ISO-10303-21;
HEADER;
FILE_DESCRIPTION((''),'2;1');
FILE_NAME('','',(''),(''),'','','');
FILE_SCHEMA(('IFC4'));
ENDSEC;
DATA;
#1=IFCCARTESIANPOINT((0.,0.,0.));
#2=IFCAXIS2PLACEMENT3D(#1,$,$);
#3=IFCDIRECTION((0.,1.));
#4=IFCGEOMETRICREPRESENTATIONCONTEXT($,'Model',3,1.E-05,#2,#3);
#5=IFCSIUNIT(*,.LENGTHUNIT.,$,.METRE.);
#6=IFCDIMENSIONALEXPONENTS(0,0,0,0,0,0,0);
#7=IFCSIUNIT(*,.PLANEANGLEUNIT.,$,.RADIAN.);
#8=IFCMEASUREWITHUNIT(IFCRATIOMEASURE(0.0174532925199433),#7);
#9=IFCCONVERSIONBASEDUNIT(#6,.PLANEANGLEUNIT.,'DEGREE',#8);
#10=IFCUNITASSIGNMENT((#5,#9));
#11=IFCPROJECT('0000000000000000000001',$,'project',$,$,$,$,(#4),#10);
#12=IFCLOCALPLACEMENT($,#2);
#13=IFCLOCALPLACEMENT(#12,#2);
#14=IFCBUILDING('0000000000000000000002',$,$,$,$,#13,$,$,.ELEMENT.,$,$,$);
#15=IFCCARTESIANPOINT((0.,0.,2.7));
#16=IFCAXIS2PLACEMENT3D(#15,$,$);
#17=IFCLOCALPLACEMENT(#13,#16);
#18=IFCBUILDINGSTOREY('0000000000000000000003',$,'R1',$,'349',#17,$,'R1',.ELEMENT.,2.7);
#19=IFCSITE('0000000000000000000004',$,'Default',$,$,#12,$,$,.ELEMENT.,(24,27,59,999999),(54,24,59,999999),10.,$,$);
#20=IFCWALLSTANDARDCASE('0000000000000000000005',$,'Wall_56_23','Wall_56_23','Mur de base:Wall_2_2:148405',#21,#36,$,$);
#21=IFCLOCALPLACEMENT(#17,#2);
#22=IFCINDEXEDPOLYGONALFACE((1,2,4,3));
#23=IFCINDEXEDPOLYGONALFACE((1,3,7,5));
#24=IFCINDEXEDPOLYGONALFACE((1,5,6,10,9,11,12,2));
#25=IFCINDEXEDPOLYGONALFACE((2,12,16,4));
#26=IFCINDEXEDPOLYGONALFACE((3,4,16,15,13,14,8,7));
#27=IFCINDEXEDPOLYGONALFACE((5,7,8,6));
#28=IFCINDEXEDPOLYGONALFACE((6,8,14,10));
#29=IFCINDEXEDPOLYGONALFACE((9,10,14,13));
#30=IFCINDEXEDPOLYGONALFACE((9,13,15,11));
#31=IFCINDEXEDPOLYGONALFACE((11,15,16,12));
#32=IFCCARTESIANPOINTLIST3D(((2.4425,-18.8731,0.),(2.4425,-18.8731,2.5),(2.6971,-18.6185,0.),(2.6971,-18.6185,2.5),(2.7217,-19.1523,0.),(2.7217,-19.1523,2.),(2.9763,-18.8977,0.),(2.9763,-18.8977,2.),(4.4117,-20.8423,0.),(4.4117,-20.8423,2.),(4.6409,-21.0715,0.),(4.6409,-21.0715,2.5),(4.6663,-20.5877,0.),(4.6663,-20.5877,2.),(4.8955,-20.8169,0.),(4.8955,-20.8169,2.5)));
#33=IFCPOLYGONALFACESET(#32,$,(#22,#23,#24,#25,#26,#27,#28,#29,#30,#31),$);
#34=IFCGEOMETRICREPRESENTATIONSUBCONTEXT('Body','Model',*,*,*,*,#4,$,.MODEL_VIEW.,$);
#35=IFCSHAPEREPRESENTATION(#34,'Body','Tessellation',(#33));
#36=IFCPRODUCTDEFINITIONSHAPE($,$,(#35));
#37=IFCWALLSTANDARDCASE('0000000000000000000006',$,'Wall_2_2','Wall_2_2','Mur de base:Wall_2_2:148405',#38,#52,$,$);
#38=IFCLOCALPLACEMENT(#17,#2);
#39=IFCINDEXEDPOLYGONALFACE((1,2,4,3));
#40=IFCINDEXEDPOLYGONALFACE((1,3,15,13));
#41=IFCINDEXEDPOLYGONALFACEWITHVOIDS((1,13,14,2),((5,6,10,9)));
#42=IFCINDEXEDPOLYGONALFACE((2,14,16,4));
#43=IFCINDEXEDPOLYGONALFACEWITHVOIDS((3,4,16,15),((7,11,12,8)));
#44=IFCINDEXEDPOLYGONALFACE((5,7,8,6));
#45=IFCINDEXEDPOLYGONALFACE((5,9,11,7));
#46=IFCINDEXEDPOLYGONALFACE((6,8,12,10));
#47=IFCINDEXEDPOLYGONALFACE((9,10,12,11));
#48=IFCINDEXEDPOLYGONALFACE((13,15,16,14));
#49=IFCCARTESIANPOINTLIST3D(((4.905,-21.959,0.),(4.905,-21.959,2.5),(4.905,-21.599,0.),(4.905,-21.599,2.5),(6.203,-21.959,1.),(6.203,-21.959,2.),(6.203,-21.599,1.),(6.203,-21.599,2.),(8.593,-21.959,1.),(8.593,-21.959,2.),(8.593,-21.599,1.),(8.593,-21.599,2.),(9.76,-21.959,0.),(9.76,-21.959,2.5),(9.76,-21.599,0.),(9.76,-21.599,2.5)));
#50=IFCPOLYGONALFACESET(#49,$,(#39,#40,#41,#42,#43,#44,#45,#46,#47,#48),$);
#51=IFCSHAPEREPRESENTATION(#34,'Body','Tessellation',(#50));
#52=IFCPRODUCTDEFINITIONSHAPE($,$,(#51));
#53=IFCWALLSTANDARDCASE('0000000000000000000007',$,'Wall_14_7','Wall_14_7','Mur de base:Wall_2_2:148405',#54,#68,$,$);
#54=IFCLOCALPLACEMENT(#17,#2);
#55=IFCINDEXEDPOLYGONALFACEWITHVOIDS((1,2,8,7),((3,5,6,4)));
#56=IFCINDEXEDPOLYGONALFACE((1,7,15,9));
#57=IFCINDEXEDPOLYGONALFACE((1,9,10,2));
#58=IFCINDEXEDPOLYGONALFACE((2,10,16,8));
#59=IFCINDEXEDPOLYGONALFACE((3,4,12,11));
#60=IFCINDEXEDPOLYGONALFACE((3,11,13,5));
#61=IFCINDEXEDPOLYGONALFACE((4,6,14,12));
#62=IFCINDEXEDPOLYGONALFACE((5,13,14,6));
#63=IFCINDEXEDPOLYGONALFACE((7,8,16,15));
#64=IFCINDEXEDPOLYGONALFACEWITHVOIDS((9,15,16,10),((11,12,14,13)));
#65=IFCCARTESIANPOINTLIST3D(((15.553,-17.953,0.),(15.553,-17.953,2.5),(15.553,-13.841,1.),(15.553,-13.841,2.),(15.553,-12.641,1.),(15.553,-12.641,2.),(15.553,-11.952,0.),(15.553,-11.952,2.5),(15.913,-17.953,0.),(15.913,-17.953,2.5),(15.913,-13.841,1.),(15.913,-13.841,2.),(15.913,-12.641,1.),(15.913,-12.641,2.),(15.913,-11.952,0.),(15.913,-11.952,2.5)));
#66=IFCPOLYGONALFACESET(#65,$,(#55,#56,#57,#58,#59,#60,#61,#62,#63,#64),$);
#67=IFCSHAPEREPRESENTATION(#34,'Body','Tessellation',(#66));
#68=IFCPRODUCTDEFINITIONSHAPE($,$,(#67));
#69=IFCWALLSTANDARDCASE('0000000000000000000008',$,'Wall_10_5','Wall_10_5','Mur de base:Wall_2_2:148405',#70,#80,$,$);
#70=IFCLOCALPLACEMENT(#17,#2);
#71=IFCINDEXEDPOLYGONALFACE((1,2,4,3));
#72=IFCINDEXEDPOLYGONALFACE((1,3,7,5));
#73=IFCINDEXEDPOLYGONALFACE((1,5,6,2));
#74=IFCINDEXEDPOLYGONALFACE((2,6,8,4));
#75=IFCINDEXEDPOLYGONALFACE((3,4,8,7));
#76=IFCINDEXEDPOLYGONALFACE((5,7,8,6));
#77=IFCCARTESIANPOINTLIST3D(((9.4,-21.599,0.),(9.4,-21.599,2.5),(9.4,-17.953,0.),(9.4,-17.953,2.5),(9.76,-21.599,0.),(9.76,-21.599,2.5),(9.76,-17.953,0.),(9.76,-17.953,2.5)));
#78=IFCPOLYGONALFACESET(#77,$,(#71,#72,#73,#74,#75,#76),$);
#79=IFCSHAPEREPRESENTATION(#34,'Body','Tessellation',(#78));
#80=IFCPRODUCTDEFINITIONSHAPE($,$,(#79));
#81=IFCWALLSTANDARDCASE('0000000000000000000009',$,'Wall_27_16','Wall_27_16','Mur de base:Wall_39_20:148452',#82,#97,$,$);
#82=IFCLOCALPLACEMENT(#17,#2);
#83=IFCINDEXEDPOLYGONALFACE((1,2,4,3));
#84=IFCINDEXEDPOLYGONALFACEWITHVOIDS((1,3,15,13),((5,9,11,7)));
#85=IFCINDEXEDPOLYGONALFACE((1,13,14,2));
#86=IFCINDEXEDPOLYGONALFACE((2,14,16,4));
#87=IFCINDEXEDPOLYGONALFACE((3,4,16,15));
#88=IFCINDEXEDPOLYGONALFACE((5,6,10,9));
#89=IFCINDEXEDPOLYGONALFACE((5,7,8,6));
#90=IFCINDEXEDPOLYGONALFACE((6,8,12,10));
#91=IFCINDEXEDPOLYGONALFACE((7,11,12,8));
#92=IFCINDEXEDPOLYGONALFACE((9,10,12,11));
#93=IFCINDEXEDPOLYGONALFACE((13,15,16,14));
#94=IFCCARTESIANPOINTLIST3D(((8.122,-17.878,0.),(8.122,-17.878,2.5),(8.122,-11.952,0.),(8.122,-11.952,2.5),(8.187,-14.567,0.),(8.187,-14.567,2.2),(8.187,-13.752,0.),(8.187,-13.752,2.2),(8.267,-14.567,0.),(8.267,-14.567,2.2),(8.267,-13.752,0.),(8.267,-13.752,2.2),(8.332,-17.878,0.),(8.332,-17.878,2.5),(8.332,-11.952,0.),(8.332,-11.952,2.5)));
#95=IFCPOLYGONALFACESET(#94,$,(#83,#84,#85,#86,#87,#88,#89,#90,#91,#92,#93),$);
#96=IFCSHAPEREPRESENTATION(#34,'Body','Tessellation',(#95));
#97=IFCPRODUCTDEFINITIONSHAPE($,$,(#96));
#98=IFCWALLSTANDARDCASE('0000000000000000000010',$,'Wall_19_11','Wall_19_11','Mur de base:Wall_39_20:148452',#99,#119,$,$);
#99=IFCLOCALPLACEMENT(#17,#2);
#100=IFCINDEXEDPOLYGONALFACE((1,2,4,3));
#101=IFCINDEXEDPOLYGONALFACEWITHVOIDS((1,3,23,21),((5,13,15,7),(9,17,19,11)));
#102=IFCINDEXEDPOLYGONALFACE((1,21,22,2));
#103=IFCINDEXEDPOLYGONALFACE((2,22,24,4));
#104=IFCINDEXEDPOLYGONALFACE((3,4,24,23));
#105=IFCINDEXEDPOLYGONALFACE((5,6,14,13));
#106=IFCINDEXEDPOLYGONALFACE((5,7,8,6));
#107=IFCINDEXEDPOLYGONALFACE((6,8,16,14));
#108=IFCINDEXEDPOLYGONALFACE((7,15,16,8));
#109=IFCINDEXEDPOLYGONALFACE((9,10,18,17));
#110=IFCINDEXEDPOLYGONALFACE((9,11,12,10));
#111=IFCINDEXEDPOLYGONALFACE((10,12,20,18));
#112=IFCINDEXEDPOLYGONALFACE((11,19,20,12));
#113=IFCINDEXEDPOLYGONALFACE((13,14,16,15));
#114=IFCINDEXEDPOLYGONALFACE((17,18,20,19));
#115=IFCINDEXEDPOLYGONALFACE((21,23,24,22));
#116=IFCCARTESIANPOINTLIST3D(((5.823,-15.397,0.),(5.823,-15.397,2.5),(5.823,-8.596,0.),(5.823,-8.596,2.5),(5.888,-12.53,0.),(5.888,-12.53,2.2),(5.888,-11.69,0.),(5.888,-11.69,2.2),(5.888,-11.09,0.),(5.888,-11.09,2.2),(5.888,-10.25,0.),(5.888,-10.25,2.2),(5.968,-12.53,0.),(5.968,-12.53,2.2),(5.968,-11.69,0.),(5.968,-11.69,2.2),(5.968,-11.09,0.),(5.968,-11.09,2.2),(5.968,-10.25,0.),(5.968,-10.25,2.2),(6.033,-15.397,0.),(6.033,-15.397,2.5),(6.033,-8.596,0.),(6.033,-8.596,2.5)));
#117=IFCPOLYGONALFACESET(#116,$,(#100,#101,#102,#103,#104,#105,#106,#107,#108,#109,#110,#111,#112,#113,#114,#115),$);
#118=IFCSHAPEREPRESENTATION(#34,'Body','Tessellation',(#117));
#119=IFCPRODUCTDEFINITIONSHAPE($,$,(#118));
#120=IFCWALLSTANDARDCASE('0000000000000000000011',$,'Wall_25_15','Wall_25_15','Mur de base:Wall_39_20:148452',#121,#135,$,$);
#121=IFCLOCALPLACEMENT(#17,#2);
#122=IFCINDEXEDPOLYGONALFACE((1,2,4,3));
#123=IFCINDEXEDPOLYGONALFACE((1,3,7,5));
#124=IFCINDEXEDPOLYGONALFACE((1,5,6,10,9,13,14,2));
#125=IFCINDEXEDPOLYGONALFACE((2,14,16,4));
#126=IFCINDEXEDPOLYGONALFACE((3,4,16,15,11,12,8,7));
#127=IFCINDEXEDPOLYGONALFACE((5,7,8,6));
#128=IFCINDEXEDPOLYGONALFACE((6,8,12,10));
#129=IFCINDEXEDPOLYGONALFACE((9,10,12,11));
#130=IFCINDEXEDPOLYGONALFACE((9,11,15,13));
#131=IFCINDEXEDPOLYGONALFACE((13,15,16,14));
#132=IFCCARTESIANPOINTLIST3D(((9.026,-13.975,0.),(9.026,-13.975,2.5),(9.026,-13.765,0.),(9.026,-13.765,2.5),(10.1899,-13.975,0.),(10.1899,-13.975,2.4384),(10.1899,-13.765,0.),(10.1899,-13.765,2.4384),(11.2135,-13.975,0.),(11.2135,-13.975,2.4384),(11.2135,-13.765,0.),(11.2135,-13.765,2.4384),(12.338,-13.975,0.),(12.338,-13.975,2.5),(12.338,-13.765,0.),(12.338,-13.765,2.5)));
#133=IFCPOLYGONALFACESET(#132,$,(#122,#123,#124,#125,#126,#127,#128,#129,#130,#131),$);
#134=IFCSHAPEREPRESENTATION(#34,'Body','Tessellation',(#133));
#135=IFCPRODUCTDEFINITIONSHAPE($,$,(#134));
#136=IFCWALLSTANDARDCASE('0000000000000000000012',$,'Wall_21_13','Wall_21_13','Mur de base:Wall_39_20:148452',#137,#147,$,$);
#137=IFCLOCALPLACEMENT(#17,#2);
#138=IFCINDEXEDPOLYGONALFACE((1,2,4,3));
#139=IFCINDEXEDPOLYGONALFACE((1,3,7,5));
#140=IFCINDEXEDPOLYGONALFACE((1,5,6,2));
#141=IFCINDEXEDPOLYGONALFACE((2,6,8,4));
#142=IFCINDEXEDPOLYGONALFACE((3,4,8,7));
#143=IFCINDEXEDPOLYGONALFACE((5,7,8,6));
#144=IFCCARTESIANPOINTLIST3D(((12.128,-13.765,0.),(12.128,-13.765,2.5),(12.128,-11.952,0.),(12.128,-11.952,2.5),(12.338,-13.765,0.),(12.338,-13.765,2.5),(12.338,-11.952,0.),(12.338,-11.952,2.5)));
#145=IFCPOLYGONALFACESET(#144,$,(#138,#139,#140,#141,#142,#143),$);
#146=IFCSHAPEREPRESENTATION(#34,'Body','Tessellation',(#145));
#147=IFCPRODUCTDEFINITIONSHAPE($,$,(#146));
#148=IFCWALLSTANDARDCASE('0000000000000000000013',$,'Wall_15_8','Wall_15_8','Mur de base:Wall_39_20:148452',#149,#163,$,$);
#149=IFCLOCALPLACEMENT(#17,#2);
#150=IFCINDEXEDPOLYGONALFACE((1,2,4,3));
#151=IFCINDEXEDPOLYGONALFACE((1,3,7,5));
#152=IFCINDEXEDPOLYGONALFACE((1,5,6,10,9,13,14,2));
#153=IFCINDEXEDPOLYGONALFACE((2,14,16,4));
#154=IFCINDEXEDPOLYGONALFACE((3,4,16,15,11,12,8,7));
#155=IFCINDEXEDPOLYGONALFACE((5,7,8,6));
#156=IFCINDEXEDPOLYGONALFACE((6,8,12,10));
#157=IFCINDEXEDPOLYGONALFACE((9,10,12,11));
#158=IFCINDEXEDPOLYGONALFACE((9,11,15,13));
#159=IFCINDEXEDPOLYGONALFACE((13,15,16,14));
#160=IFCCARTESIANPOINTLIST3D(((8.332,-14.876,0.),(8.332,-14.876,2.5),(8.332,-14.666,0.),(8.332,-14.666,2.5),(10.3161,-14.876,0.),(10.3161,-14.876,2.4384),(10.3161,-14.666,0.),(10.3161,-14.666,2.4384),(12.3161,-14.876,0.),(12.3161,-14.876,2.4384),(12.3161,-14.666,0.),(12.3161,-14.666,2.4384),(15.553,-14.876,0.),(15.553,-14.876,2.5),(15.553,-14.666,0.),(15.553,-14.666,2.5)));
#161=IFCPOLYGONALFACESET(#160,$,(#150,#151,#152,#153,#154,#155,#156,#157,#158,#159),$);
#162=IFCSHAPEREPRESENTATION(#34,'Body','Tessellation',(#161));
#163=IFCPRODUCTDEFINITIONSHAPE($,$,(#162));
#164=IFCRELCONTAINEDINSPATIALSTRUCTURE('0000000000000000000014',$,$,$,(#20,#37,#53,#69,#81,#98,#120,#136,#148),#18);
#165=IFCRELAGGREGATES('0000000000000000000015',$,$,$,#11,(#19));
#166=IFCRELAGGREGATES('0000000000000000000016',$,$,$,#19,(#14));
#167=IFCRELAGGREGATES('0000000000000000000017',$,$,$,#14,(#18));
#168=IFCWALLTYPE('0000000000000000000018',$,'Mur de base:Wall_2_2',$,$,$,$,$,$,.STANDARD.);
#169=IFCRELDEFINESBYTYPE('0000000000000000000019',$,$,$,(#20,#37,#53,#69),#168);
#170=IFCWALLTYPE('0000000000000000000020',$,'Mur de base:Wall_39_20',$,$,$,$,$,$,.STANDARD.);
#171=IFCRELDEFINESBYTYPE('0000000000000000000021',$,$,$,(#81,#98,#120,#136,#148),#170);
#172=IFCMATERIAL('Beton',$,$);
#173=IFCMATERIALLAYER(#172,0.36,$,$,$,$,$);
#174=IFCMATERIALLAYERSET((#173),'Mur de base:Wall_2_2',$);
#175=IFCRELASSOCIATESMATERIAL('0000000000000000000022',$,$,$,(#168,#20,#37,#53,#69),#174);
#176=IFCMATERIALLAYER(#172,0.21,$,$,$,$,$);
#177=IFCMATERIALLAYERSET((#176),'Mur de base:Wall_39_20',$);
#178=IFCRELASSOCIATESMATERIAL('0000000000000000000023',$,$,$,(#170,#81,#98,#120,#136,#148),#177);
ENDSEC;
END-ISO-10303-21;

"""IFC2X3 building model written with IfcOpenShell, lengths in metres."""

from ifc_helpers import new_model, entity, si_unit, converted_unit, direction, frame, frame_2d, origin, origin_2d_with_axis, place, context, subcontext, project, spatial, rectangle, extrude, material, layer, layer_set, layer_usage, type_object, element, save


model = new_model("IFC2X3")

# Units and contexts
model_context = context("Model", 3, precision=1e-05, world=origin(), true_north=direction((0.0, 1.0)))
body_context = subcontext(model_context, "Body", "Model", "MODEL_VIEW")
ifc_project = project(units=[si_unit("LENGTHUNIT", "METRE"), converted_unit("PLANEANGLEUNIT", "DEGREE", entity("IfcRatioMeasure", 0.0174532925199433), si_unit("PLANEANGLEUNIT", "RADIAN"), dimensions=[0, 0, 0, 0, 0, 0, 0])], contexts=[model_context])

# Site, building, storey
site_placement = place(None, origin())
site = spatial("IfcSite", under=ifc_project, at=site_placement, Name="Default", CompositionType="ELEMENT", RefLatitude=(24, 27, 59, 999999), RefLongitude=(54, 24, 59, 999999), RefElevation=10.0)
building_placement = place(site_placement, origin())
building = spatial("IfcBuilding", under=site, at=building_placement, CompositionType="ELEMENT")
storey_placement = place(building_placement, frame((0.0, 0.0, 2.7)))
storey = spatial("IfcBuildingStorey", under=building, at=storey_placement, Name="R1", ObjectType="349", LongName="R1", CompositionType="ELEMENT", Elevation=2.7)

# Wall, opening
ifc_material_1 = material(Name="Beton")
ifc_layer_1 = layer(ifc_material_1, 0.36)
ifc_layer_set_1 = layer_set([ifc_layer_1], Name="Mur de base:Wall_2_2")
ifc_layer_usage_1 = layer_usage(ifc_layer_set_1, "AXIS2", "NEGATIVE", 0.18)
wall_type_1 = type_object("IfcWallType", Name="Mur de base:Wall_2_2", PredefinedType="STANDARD", material=ifc_layer_set_1)
wall_1_placement = place(storey_placement, frame((2.5698, -18.7458, 0.0), z_axis=(0.0, 0.0, 1.0), x_axis=(0.707107, -0.707107, 0.0)))
wall_1 = element("IfcWallStandardCase", 1, at=wall_1_placement, inside=storey, type_object=wall_type_1, material=ifc_layer_usage_1, Name="Wall_56_23", Description="Wall_56_23", ObjectType="Mur de base:Wall_2_2:148405", context=body_context, shape_type="SweptSolid", body=[
    extrude(rectangle(XDim=3.109, YDim=0.36, at=frame_2d((1.5545, 0.0), x_axis=(-1.0, 0.0))), origin(), (0.0, 0.0, 1.0), 2.5),
])
opening_1_placement = place(wall_1_placement, origin())
element("IfcOpeningElement", 2, at=opening_1_placement, cuts=wall_1, ObjectType="Opening", context=body_context, shape_type="SweptSolid", body=[
    extrude(rectangle(XDim=2.0, YDim=2.39, at=frame_2d((0.0, 0.0), x_axis=(1.0, 0.0))), frame((1.5898, -0.19, 1.0), z_axis=(0.0, 1.0, 0.0), x_axis=(0.0, 0.0, -1.0)), (0.0, 0.0, 1.0), 0.38),
])

# Walls, openings
ifc_layer_usage_2 = layer_usage(ifc_layer_set_1, "AXIS2", "NEGATIVE", 0.18)
wall_2_placement = place(storey_placement, frame((4.905, -21.779, 0.0)))
wall_2 = element("IfcWallStandardCase", 3, at=wall_2_placement, inside=storey, type_object=wall_type_1, material=ifc_layer_usage_2, Name="Wall_2_2", Description="Wall_2_2", ObjectType="Mur de base:Wall_2_2:148405", context=body_context, shape_type="SweptSolid", body=[
    extrude(rectangle(XDim=4.855, YDim=0.36, at=frame_2d((2.4275, 0.0), x_axis=(-1.0, 0.0))), origin(), (0.0, 0.0, 1.0), 2.5),
])
opening_2_placement = place(wall_2_placement, origin())
element("IfcOpeningElement", 4, at=opening_2_placement, cuts=wall_2, ObjectType="Opening", context=body_context, shape_type="SweptSolid", body=[
    extrude(rectangle(XDim=1.0, YDim=2.39, at=origin_2d_with_axis()), frame((2.493, -0.19, 1.5), z_axis=(0.0, 1.0, 0.0), x_axis=(0.0, 0.0, -1.0)), (0.0, 0.0, 1.0), 0.38),
])
ifc_layer_usage_3 = layer_usage(ifc_layer_set_1, "AXIS2", "NEGATIVE", 0.18)
wall_3_placement = place(storey_placement, frame((15.733, -17.953, 0.0), z_axis=(0.0, 0.0, 1.0), x_axis=(0.0, 1.0, 0.0)))
wall_3 = element("IfcWallStandardCase", 5, at=wall_3_placement, inside=storey, type_object=wall_type_1, material=ifc_layer_usage_3, Name="Wall_14_7", Description="Wall_14_7", ObjectType="Mur de base:Wall_2_2:148405", context=body_context, shape_type="SweptSolid", body=[
    extrude(rectangle(XDim=6.001, YDim=0.36, at=frame_2d((3.0005, 0.0), x_axis=(-1.0, 0.0))), origin(), (0.0, 0.0, 1.0), 2.5),
])
opening_3_placement = place(wall_3_placement, origin())
element("IfcOpeningElement", 6, at=opening_3_placement, cuts=wall_3, ObjectType="Opening", context=body_context, shape_type="SweptSolid", body=[
    extrude(rectangle(XDim=1.0, YDim=1.2, at=origin_2d_with_axis()), frame((4.712, -0.19, 1.5), z_axis=(0.0, 1.0, 0.0), x_axis=(0.0, 0.0, -1.0)), (0.0, 0.0, 1.0), 0.38),
])

# Wall
ifc_layer_usage_4 = layer_usage(ifc_layer_set_1, "AXIS2", "NEGATIVE", 0.18)
wall_4_placement = place(storey_placement, frame((9.58, -21.599, 0.0), z_axis=(0.0, 0.0, 1.0), x_axis=(0.0, 1.0, 0.0)))
element("IfcWallStandardCase", 7, at=wall_4_placement, inside=storey, type_object=wall_type_1, material=ifc_layer_usage_4, Name="Wall_10_5", Description="Wall_10_5", ObjectType="Mur de base:Wall_2_2:148405", context=body_context, shape_type="SweptSolid", body=[
    extrude(rectangle(XDim=3.646, YDim=0.36, at=frame_2d((1.823, 0.0), x_axis=(-1.0, 0.0))), origin(), (0.0, 0.0, 1.0), 2.5),
])

# Wall, opening
ifc_layer_2 = layer(ifc_material_1, 0.21)
ifc_layer_set_2 = layer_set([ifc_layer_2], Name="Mur de base:Wall_39_20")
ifc_layer_usage_5 = layer_usage(ifc_layer_set_2, "AXIS2", "NEGATIVE", 0.105)
wall_type_2 = type_object("IfcWallType", Name="Mur de base:Wall_39_20", PredefinedType="STANDARD", material=ifc_layer_set_2)
wall_5_placement = place(storey_placement, frame((8.227, -17.878, 0.0), z_axis=(0.0, 0.0, 1.0), x_axis=(0.0, 1.0, 0.0)))
wall_5 = element("IfcWallStandardCase", 8, at=wall_5_placement, inside=storey, type_object=wall_type_2, material=ifc_layer_usage_5, Name="Wall_27_16", Description="Wall_27_16", ObjectType="Mur de base:Wall_39_20:148452", context=body_context, shape_type="SweptSolid", body=[
    extrude(rectangle(XDim=5.926, YDim=0.21, at=frame_2d((2.963, 0.0), x_axis=(-1.0, 0.0))), origin(), (0.0, 0.0, 1.0), 2.5),
])
opening_4_placement = place(wall_5_placement, origin())
element("IfcOpeningElement", 9, at=opening_4_placement, cuts=wall_5, ObjectType="Recess", context=body_context, shape_type="SweptSolid", body=[
    extrude(rectangle(XDim=2.2, YDim=0.815, at=frame_2d((0.0, 0.0), x_axis=(1.0, 0.0))), frame((3.7185, -0.04, 1.1), z_axis=(0.0, 1.0, 0.0), x_axis=(0.0, 0.0, -1.0)), (0.0, 0.0, 1.0), 0.08),
])

# Wall, openings
ifc_layer_usage_6 = layer_usage(ifc_layer_set_2, "AXIS2", "NEGATIVE", 0.105)
wall_6_placement = place(storey_placement, frame((5.928, -15.397, 0.0), z_axis=(0.0, 0.0, 1.0), x_axis=(0.0, 1.0, 0.0)))
wall_6 = element("IfcWallStandardCase", 10, at=wall_6_placement, inside=storey, type_object=wall_type_2, material=ifc_layer_usage_6, Name="Wall_19_11", Description="Wall_19_11", ObjectType="Mur de base:Wall_39_20:148452", context=body_context, shape_type="SweptSolid", body=[
    extrude(rectangle(XDim=6.801, YDim=0.21, at=frame_2d((3.4005, 0.0), x_axis=(-1.0, 0.0))), origin(), (0.0, 0.0, 1.0), 2.5),
])
opening_5_placement = place(wall_6_placement, origin())
element("IfcOpeningElement", 11, at=opening_5_placement, cuts=wall_6, ObjectType="Recess", context=body_context, shape_type="SweptSolid", body=[
    extrude(rectangle(XDim=2.2, YDim=0.84, at=origin_2d_with_axis()), frame((3.287, -0.04, 1.1), z_axis=(0.0, 1.0, 0.0), x_axis=(0.0, 0.0, -1.0)), (0.0, 0.0, 1.0), 0.08),
])
opening_6_placement = place(wall_6_placement, origin())
element("IfcOpeningElement", 12, at=opening_6_placement, cuts=wall_6, ObjectType="Recess", context=body_context, shape_type="SweptSolid", body=[
    extrude(rectangle(XDim=2.2, YDim=0.84, at=origin_2d_with_axis()), frame((4.727, -0.04, 1.1), z_axis=(0.0, 1.0, 0.0), x_axis=(0.0, 0.0, -1.0)), (0.0, 0.0, 1.0), 0.08),
])

# Wall, opening
ifc_layer_usage_7 = layer_usage(ifc_layer_set_2, "AXIS2", "NEGATIVE", 0.105)
wall_7_placement = place(storey_placement, frame((9.026, -13.87, 0.0)))
wall_7 = element("IfcWallStandardCase", 13, at=wall_7_placement, inside=storey, type_object=wall_type_2, material=ifc_layer_usage_7, Name="Wall_25_15", Description="Wall_25_15", ObjectType="Mur de base:Wall_39_20:148452", context=body_context, shape_type="SweptSolid", body=[
    extrude(rectangle(XDim=3.312, YDim=0.21, at=frame_2d((1.656, 0.0), x_axis=(-1.0, 0.0))), origin(), (0.0, 0.0, 1.0), 2.5),
])
opening_7_placement = place(wall_7_placement, origin())
element("IfcOpeningElement", 14, at=opening_7_placement, cuts=wall_7, ObjectType="Opening", context=body_context, shape_type="SweptSolid", body=[
    extrude(rectangle(XDim=2.4384, YDim=1.0236, at=frame_2d((0.0, 0.0), x_axis=(1.0, 0.0))), frame((1.6757, -0.105, 1.2192), z_axis=(0.0, 1.0, 0.0), x_axis=(0.0, 0.0, -1.0)), (0.0, 0.0, 1.0), 0.21),
])

# Wall
ifc_layer_usage_8 = layer_usage(ifc_layer_set_2, "AXIS2", "NEGATIVE", 0.105)
wall_8_placement = place(storey_placement, frame((12.233, -13.765, 0.0), z_axis=(0.0, 0.0, 1.0), x_axis=(0.0, 1.0, 0.0)))
element("IfcWallStandardCase", 15, at=wall_8_placement, inside=storey, type_object=wall_type_2, material=ifc_layer_usage_8, Name="Wall_21_13", Description="Wall_21_13", ObjectType="Mur de base:Wall_39_20:148452", context=body_context, shape_type="SweptSolid", body=[
    extrude(rectangle(XDim=1.813, YDim=0.21, at=frame_2d((0.9065, 0.0), x_axis=(-1.0, 0.0))), origin(), (0.0, 0.0, 1.0), 2.5),
])

# Wall, opening
ifc_layer_usage_9 = layer_usage(ifc_layer_set_2, "AXIS2", "NEGATIVE", 0.105)
wall_9_placement = place(storey_placement, frame((8.332, -14.771, 0.0)))
wall_9 = element("IfcWallStandardCase", 16, at=wall_9_placement, inside=storey, type_object=wall_type_2, material=ifc_layer_usage_9, Name="Wall_15_8", Description="Wall_15_8", ObjectType="Mur de base:Wall_39_20:148452", context=body_context, shape_type="SweptSolid", body=[
    extrude(rectangle(XDim=7.221, YDim=0.21, at=frame_2d((3.6105, 0.0), x_axis=(-1.0, 0.0))), origin(), (0.0, 0.0, 1.0), 2.5),
])
opening_8_placement = place(wall_9_placement, origin())
element("IfcOpeningElement", 17, at=opening_8_placement, cuts=wall_9, ObjectType="Opening", context=body_context, shape_type="SweptSolid", body=[
    extrude(rectangle(XDim=2.4384, YDim=2.0, at=origin_2d_with_axis()), frame((2.9841, -0.105, 1.2192), z_axis=(0.0, 1.0, 0.0), x_axis=(0.0, 0.0, -1.0)), (0.0, 0.0, 1.0), 0.21),
])

save(model, "model.ifc")
